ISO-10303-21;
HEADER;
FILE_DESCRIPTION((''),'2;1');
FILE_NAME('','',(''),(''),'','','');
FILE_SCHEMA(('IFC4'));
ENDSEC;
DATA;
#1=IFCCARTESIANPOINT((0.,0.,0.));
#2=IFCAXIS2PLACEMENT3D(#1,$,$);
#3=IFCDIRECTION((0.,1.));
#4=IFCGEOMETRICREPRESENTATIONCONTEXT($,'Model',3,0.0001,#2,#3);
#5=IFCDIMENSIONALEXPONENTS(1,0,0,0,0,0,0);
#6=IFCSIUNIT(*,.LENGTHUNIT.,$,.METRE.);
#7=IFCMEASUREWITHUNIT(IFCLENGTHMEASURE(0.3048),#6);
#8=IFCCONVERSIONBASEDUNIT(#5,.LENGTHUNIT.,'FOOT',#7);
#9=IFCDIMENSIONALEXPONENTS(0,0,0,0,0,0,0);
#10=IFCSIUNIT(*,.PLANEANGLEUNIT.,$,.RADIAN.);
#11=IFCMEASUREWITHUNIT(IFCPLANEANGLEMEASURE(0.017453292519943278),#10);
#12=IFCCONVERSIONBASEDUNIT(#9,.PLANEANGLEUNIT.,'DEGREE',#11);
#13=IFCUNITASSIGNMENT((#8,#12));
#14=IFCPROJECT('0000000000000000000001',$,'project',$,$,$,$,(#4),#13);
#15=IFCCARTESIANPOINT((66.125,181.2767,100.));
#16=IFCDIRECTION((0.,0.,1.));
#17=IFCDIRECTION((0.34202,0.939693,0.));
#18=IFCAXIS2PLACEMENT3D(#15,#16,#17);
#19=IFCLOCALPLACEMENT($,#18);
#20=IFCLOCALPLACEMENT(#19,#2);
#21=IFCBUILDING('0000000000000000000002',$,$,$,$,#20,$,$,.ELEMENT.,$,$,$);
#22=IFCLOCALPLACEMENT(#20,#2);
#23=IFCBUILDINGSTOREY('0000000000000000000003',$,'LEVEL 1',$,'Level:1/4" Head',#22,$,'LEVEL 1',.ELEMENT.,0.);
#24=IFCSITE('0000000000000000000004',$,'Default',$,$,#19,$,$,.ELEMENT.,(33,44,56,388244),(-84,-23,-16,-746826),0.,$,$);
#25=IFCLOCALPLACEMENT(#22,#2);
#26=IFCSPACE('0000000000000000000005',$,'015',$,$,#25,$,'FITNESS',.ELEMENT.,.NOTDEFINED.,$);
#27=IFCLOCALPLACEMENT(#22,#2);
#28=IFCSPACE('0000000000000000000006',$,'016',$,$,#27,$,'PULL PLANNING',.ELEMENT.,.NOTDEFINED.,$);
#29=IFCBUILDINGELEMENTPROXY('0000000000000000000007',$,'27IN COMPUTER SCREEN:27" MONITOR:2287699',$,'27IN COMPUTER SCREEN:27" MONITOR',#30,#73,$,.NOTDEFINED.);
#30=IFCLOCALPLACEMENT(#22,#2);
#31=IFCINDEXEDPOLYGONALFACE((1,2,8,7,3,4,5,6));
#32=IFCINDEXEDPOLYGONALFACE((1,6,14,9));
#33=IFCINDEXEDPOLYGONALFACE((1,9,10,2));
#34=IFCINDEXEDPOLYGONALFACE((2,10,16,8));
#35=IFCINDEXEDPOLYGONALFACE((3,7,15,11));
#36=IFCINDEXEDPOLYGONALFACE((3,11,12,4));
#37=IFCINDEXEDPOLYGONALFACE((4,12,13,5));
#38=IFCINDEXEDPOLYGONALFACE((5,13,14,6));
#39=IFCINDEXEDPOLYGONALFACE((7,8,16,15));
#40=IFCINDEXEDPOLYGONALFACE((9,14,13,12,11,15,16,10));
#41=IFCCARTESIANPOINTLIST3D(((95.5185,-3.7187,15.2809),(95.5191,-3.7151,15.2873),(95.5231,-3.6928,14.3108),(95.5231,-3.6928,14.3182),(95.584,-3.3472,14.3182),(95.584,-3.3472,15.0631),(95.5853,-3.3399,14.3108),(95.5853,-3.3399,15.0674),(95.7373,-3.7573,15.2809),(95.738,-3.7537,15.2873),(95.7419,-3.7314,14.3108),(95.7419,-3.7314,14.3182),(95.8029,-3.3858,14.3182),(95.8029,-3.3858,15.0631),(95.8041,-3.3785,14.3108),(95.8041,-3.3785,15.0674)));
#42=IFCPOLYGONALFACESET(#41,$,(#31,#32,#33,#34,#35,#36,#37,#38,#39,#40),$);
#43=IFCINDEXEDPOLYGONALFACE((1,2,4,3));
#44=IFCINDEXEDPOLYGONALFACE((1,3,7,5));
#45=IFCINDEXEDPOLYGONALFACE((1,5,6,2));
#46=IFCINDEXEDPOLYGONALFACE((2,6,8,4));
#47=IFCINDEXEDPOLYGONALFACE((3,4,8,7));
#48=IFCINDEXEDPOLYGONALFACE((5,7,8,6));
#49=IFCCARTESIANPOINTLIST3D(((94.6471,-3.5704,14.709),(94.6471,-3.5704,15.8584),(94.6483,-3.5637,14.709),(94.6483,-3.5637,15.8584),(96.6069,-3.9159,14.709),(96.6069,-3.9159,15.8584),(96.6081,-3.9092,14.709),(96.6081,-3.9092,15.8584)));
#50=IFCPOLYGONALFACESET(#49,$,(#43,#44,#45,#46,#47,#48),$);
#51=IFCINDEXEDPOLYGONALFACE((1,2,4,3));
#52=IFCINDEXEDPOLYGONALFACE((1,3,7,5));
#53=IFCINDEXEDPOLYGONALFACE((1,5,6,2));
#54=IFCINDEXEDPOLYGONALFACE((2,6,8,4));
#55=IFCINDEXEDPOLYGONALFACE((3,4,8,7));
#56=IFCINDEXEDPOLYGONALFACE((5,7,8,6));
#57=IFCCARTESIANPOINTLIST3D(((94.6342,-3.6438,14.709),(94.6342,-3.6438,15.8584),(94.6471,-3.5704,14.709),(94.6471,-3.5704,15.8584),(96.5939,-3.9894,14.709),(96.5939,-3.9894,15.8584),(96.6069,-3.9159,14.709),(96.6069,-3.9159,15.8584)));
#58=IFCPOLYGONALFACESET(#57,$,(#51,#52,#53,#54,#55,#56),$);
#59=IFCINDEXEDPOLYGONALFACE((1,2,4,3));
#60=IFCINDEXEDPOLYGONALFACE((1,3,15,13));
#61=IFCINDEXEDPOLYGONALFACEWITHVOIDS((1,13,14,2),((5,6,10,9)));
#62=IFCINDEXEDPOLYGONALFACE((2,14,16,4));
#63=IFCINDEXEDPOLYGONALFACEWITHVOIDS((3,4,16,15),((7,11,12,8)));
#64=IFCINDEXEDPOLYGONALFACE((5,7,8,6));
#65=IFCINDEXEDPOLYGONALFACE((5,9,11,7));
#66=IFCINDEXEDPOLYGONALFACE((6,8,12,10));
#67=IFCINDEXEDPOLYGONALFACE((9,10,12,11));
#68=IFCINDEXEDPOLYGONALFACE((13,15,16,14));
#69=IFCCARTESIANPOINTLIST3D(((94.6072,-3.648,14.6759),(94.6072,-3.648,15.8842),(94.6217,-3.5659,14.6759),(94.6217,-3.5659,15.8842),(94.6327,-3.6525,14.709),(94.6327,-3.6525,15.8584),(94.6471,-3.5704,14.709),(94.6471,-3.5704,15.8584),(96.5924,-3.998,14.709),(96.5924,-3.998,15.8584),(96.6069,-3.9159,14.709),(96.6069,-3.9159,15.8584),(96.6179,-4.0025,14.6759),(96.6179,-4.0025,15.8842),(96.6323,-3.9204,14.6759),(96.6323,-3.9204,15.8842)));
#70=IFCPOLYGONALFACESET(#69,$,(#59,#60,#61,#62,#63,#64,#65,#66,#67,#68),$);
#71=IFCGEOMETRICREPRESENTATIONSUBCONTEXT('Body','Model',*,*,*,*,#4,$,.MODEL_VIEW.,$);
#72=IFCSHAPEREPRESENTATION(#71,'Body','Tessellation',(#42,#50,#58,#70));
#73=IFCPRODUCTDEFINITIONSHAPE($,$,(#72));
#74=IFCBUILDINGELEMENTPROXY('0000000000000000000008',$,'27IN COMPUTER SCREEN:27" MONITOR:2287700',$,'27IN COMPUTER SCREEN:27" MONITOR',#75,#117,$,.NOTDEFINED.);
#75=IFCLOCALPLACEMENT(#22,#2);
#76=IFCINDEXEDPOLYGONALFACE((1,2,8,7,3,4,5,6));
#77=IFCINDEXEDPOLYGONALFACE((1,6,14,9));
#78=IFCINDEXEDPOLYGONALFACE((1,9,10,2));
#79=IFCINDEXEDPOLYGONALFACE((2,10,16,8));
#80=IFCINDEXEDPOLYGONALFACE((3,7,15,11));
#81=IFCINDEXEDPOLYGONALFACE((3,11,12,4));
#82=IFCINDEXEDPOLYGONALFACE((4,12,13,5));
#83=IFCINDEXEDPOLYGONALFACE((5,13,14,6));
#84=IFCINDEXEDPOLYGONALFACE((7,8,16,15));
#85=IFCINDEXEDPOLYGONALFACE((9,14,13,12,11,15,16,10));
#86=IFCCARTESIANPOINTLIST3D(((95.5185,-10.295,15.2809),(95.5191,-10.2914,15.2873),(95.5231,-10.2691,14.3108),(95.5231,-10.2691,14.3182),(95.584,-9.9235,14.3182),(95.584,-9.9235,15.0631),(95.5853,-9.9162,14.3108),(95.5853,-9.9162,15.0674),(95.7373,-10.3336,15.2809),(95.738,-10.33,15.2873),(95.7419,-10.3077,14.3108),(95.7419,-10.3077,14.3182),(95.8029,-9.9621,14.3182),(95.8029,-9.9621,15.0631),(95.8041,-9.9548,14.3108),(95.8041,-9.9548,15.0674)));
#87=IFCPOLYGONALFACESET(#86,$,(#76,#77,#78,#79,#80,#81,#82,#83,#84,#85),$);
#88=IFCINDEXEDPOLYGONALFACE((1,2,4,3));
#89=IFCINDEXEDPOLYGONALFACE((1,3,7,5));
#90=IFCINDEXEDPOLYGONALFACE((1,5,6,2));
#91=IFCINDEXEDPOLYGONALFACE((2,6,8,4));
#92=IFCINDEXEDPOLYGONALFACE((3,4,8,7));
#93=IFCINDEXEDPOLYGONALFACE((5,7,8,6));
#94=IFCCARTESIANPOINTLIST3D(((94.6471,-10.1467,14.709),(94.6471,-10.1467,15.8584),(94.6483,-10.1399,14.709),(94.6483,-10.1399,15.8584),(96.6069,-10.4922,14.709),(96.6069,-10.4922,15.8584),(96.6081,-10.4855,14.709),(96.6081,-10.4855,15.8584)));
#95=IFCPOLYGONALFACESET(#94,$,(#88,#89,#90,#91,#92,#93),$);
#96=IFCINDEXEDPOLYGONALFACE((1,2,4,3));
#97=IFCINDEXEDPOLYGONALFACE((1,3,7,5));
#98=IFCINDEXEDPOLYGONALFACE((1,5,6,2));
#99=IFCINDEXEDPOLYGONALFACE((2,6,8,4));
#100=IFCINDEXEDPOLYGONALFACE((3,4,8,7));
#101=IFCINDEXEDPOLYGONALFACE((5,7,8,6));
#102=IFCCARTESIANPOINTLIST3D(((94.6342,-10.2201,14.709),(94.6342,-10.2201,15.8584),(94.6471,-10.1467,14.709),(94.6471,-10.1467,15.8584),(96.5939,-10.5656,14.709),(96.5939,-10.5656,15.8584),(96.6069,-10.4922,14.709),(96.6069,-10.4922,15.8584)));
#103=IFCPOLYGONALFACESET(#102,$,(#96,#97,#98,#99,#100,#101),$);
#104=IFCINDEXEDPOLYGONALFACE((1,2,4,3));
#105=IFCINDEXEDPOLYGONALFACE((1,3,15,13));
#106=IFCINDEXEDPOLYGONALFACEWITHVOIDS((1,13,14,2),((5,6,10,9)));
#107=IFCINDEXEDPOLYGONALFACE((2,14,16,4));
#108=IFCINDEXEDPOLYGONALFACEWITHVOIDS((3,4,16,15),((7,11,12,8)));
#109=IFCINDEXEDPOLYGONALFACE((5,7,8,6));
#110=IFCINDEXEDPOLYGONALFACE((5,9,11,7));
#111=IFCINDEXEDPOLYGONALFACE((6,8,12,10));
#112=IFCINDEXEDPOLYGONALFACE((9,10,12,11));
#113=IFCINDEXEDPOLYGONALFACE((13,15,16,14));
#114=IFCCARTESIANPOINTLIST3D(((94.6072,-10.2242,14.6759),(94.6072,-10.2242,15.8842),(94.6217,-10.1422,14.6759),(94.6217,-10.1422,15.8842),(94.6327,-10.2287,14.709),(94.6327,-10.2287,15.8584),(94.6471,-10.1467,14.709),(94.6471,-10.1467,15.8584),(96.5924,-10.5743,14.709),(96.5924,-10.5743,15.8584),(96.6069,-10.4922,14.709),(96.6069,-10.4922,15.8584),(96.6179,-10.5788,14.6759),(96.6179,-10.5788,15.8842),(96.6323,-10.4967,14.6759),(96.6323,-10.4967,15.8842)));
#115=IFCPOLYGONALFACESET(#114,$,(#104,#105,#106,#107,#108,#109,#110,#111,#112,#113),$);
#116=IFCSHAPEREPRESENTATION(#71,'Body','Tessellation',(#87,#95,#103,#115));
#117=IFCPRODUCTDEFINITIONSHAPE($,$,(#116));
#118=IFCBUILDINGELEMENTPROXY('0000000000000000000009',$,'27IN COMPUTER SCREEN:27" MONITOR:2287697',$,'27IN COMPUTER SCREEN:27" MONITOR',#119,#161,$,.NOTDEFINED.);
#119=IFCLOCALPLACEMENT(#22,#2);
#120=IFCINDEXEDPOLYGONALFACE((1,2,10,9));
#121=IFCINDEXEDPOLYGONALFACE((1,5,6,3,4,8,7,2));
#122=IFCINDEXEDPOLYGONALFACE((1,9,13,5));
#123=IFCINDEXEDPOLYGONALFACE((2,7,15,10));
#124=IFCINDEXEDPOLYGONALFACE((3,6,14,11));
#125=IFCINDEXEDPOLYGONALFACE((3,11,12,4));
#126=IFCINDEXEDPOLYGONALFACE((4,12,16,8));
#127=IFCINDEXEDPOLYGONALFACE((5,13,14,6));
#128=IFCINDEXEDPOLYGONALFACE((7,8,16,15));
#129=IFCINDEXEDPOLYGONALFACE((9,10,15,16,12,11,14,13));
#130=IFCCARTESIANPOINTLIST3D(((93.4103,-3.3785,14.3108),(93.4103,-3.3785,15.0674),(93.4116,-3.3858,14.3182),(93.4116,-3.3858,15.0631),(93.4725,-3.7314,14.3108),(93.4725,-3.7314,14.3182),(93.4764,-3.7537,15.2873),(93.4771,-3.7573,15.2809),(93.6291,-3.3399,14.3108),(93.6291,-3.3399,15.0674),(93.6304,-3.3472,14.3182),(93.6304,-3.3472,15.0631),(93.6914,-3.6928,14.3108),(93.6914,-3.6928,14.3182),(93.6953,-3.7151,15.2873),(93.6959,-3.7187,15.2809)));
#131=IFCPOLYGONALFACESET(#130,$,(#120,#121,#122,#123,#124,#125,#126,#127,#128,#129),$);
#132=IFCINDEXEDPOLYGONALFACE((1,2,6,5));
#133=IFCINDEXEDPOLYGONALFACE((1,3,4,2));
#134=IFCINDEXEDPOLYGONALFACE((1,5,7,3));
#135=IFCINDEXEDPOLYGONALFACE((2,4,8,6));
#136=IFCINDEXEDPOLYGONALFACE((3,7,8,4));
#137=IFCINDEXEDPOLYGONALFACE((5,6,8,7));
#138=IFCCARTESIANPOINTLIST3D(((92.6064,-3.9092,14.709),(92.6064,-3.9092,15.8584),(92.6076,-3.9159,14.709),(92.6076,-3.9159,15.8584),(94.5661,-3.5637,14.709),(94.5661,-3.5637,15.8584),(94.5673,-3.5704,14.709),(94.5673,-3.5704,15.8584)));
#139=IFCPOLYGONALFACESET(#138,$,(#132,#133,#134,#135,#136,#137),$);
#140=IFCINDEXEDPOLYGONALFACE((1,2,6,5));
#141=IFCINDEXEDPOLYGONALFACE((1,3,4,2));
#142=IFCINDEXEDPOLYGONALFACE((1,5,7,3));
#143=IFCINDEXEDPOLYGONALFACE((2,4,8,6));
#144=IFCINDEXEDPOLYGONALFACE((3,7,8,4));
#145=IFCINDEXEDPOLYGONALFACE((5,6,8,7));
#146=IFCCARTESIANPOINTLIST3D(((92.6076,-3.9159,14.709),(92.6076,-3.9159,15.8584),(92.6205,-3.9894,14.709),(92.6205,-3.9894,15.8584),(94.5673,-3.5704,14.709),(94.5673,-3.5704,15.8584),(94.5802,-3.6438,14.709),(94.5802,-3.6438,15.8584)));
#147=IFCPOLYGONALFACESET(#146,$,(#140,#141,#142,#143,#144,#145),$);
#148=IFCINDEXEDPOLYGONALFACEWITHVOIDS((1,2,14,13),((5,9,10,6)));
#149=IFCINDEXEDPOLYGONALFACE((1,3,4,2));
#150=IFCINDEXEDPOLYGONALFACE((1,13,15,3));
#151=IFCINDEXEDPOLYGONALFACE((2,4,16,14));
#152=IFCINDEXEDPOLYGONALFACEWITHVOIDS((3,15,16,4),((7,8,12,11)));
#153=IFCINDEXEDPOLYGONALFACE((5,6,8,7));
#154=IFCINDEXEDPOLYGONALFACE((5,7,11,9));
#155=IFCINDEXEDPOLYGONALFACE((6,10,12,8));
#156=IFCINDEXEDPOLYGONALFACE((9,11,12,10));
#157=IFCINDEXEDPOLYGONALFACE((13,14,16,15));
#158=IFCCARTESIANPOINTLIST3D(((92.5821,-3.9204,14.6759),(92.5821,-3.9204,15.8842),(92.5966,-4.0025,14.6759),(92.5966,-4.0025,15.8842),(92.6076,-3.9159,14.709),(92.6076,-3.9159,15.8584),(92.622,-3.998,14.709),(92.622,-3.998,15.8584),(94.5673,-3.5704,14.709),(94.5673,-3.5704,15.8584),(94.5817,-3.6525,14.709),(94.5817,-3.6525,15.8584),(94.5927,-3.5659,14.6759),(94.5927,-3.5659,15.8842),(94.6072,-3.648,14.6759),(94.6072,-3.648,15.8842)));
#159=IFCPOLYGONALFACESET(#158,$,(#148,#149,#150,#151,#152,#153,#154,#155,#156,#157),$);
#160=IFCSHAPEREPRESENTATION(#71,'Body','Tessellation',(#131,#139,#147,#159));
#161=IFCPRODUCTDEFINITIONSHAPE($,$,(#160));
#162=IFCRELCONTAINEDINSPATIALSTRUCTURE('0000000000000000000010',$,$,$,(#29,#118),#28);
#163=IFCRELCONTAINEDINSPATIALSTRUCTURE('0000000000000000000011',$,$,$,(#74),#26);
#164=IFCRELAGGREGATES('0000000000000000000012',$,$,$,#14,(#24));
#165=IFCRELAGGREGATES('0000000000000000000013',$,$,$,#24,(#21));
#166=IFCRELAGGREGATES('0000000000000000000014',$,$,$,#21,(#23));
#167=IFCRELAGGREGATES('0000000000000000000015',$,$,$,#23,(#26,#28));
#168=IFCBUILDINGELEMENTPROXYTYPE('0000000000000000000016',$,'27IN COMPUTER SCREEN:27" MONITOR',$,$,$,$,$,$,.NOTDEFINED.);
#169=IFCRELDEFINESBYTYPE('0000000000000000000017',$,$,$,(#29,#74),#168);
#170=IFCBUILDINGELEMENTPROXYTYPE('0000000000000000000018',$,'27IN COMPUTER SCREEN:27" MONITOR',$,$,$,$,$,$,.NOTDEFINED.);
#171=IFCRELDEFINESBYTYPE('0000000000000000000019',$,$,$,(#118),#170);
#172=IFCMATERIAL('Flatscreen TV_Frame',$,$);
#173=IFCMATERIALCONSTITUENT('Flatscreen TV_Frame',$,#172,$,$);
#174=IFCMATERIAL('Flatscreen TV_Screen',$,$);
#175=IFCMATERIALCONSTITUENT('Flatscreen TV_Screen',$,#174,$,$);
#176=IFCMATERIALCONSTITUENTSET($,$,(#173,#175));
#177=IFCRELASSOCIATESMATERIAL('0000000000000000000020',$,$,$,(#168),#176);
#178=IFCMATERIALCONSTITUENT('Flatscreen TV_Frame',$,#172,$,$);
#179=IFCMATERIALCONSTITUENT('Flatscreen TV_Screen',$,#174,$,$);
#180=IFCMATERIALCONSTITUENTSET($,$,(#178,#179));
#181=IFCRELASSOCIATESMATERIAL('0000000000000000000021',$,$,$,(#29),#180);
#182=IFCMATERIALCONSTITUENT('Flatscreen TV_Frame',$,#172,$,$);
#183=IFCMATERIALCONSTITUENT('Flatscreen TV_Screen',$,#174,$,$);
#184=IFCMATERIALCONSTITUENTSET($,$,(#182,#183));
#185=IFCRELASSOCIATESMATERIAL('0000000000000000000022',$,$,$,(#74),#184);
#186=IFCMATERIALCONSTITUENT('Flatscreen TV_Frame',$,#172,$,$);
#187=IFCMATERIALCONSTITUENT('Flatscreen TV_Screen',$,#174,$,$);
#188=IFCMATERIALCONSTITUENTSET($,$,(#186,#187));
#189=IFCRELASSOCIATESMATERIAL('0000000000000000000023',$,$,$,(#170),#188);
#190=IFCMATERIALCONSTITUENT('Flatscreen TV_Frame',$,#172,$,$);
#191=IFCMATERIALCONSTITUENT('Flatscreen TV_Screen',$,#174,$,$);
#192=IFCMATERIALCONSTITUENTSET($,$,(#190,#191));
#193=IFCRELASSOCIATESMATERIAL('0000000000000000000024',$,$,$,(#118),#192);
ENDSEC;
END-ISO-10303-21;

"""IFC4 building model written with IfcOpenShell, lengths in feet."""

from ifc_helpers import new_model, entity, si_unit, converted_unit, direction, frame, frame_2d, origin, origin_2d_with_axis, place, context, subcontext, project, spatial, polyline, rectangle, outline, extrude, source, transform, mapped, material, constituent, constituent_set, type_object, type_shapes, element, save


model = new_model("IFC4")

# Units and contexts
model_context = context("Model", 3, precision=0.0001, world=origin(), true_north=direction((0.0, 1.0)))
body_context = subcontext(model_context, "Body", "Model", "MODEL_VIEW")
ifc_project = project(units=[converted_unit("LENGTHUNIT", "FOOT", entity("IfcLengthMeasure", 0.3048), si_unit("LENGTHUNIT", "METRE"), dimensions=[1, 0, 0, 0, 0, 0, 0]), converted_unit("PLANEANGLEUNIT", "DEGREE", entity("IfcPlaneAngleMeasure", 0.017453292519943278), si_unit("PLANEANGLEUNIT", "RADIAN"), dimensions=[0, 0, 0, 0, 0, 0, 0])], contexts=[model_context])

# Site, building, storey
site_placement = place(None, frame((66.125, 181.2767, 100.0), z_axis=(0.0, 0.0, 1.0), x_axis=(0.34202, 0.939693, 0.0)))
site = spatial("IfcSite", under=ifc_project, at=site_placement, Name="Default", CompositionType="ELEMENT", RefLatitude=(33, 44, 56, 388244), RefLongitude=(-84, -23, -16, -746826), RefElevation=0.0)
building_placement = place(site_placement, origin())
building = spatial("IfcBuilding", under=site, at=building_placement, CompositionType="ELEMENT")
storey_placement = place(building_placement, origin())
storey = spatial("IfcBuildingStorey", under=building, at=storey_placement, Name="LEVEL 1", ObjectType="Level:1/4\" Head", LongName="LEVEL 1", CompositionType="ELEMENT", Elevation=0.0)

# Shared definitions
space_1_placement = place(storey_placement, origin())
space_1 = spatial("IfcSpace", under=storey, at=space_1_placement, Name="015", LongName="FITNESS", CompositionType="ELEMENT", PredefinedType="NOTDEFINED")

# Shared definitions
ifc_material_1 = material(Name="Flatscreen TV_Frame")
ifc_material_2 = material(Name="Flatscreen TV_Screen")
ifc_constituent_1 = constituent(ifc_material_1, Name="Flatscreen TV_Frame")
ifc_constituent_2 = constituent(ifc_material_2, Name="Flatscreen TV_Screen")
ifc_constituent_set_1 = constituent_set(constituents=[ifc_constituent_1, ifc_constituent_2])
building_element_proxy_type_1 = type_object("IfcBuildingElementProxyType", Name="27IN COMPUTER SCREEN:27\" MONITOR", PredefinedType="NOTDEFINED", material=ifc_constituent_set_1)
shared_shape_1 = source(origin(), body_context, "Body", "SweptSolid", [
    extrude(outline(polyline([(-0.4392, -0.3657), (-0.4392, -0.3731), (0.0007, -0.3731), (0.379, 0.2821), (0.0686, 0.4613), (0.0649, 0.4548), (0.3688, 0.2794), (-0.0036, -0.3657), (-0.4392, -0.3657)])), frame((-0.1111, -0.0264, 0.0687), z_axis=(-1.0, 0.0, 0.0), x_axis=(0.0, 0.866025, -0.5)), (0.0, 0.0, -1.0), 0.2222),
    extrude(rectangle(XDim=0.0068, YDim=1.9899, at=origin_2d_with_axis()), frame((0.0, -0.2257, 0.0331), z_axis=(0.0, 0.0, 1.0), x_axis=(0.0, 1.0, 0.0)), (0.0, 0.0, 1.0), 1.1493),
    extrude(rectangle(XDim=0.0746, YDim=1.9899, at=frame_2d((0.0, 0.0), x_axis=(1.0, 0.0))), frame((0.0, -0.2664, 0.0331), z_axis=(0.0, 0.0, 1.0), x_axis=(0.0, 1.0, 0.0)), (0.0, 0.0, 1.0), 1.1493),
    extrude(outline(polyline([(-0.6042, -1.0208), (0.6042, -1.0208), (0.6042, 1.0208), (-0.6042, 1.0208), (-0.6042, -1.0208)]), holes=[polyline([(-0.5783, -0.995), (-0.5783, 0.995), (0.571, 0.995), (0.571, -0.995), (-0.5783, -0.995)])]), frame((0.0, -0.3125, 0.6042), z_axis=(0.0, 1.0, 0.0), x_axis=(0.0, 0.0, -1.0)), (0.0, 0.0, 1.0), 0.0833),
])
type_shapes(building_element_proxy_type_1, [shared_shape_1])

# Shared definitions
space_2_placement = place(storey_placement, origin())
space_2 = spatial("IfcSpace", under=storey, at=space_2_placement, Name="016", LongName="PULL PLANNING", CompositionType="ELEMENT", PredefinedType="NOTDEFINED")

# Building element proxies
ifc_constituent_3 = constituent(ifc_material_1, Name="Flatscreen TV_Frame")
ifc_constituent_4 = constituent(ifc_material_2, Name="Flatscreen TV_Screen")
ifc_constituent_set_2 = constituent_set(constituents=[ifc_constituent_3, ifc_constituent_4])
proxy_1_placement = place(space_2_placement, frame((95.6668, -3.5175, 14.6759), z_axis=(0.0, 0.0, 1.0), x_axis=(0.984808, -0.173648, 0.0)))
element("IfcBuildingElementProxy", 1, at=proxy_1_placement, inside=space_2, type_object=building_element_proxy_type_1, material=ifc_constituent_set_2, Name="27IN COMPUTER SCREEN:27\" MONITOR:2287699", ObjectType="27IN COMPUTER SCREEN:27\" MONITOR", PredefinedType="NOTDEFINED", context=body_context, shape_type="MappedRepresentation", body=[
    mapped(shared_shape_1, transform((0.0, 0.0, 0.0), scale=1.0)),
])
ifc_constituent_5 = constituent(ifc_material_1, Name="Flatscreen TV_Frame")
ifc_constituent_6 = constituent(ifc_material_2, Name="Flatscreen TV_Screen")
ifc_constituent_set_3 = constituent_set(constituents=[ifc_constituent_5, ifc_constituent_6])
proxy_2_placement = place(space_1_placement, frame((95.6668, -10.0938, 14.6759), z_axis=(0.0, 0.0, 1.0), x_axis=(0.984808, -0.173648, 0.0)))
element("IfcBuildingElementProxy", 2, at=proxy_2_placement, inside=space_1, type_object=building_element_proxy_type_1, material=ifc_constituent_set_3, Name="27IN COMPUTER SCREEN:27\" MONITOR:2287700", ObjectType="27IN COMPUTER SCREEN:27\" MONITOR", PredefinedType="NOTDEFINED", context=body_context, shape_type="MappedRepresentation", body=[
    mapped(shared_shape_1, transform((0.0, 0.0, 0.0), scale=1.0)),
])
ifc_constituent_7 = constituent(ifc_material_1, Name="Flatscreen TV_Frame")
ifc_constituent_8 = constituent(ifc_material_2, Name="Flatscreen TV_Screen")
ifc_constituent_set_4 = constituent_set(constituents=[ifc_constituent_7, ifc_constituent_8])
ifc_constituent_9 = constituent(ifc_material_1, Name="Flatscreen TV_Frame")
ifc_constituent_10 = constituent(ifc_material_2, Name="Flatscreen TV_Screen")
ifc_constituent_set_5 = constituent_set(constituents=[ifc_constituent_9, ifc_constituent_10])
building_element_proxy_type_2 = type_object("IfcBuildingElementProxyType", Name="27IN COMPUTER SCREEN:27\" MONITOR", PredefinedType="NOTDEFINED", material=ifc_constituent_set_5)
shared_shape_2 = source(origin(), body_context, "Body", "SweptSolid", [
    extrude(outline(polyline([(0.3657, -0.4392), (0.3731, -0.4392), (0.3731, 0.0007), (-0.2821, 0.379), (-0.4613, 0.0686), (-0.4548, 0.0649), (-0.2794, 0.3688), (0.3657, -0.0036), (0.3657, -0.4392)])), frame((-0.1111, 0.0264, 0.0687), z_axis=(1.0, 0.0, 0.0), x_axis=(0.0, -0.5, 0.866025)), (0.0, 0.0, 1.0), 0.2222),
    extrude(rectangle(XDim=1.9899, YDim=0.0068, at=origin_2d_with_axis()), frame((0.0, 0.2257, 0.0331), z_axis=(0.0, 0.0, 1.0), x_axis=(-1.0, 0.0, 0.0)), (0.0, 0.0, 1.0), 1.1493),
    extrude(rectangle(XDim=1.9899, YDim=0.0746, at=frame_2d((0.0, 0.0), x_axis=(1.0, 0.0))), frame((0.0, 0.2664, 0.0331), z_axis=(0.0, 0.0, 1.0), x_axis=(-1.0, 0.0, 0.0)), (0.0, 0.0, 1.0), 1.1493),
    extrude(outline(polyline([(-0.6042, -1.0208), (0.6042, -1.0208), (0.6042, 1.0208), (-0.6042, 1.0208), (-0.6042, -1.0208)]), holes=[polyline([(-0.5783, -0.995), (-0.5783, 0.995), (0.571, 0.995), (0.571, -0.995), (-0.5783, -0.995)])]), frame((0.0, 0.2292, 0.6042), z_axis=(0.0, 1.0, 0.0), x_axis=(0.0, 0.0, -1.0)), (0.0, 0.0, 1.0), 0.0833),
])
type_shapes(building_element_proxy_type_2, [shared_shape_2])
proxy_3_placement = place(space_2_placement, frame((93.5476, -3.5175, 14.6759), z_axis=(0.0, 0.0, 1.0), x_axis=(-0.984808, -0.173648, 0.0)))
element("IfcBuildingElementProxy", 3, at=proxy_3_placement, inside=space_2, type_object=building_element_proxy_type_2, material=ifc_constituent_set_4, Name="27IN COMPUTER SCREEN:27\" MONITOR:2287697", ObjectType="27IN COMPUTER SCREEN:27\" MONITOR", PredefinedType="NOTDEFINED", context=body_context, shape_type="MappedRepresentation", body=[
    mapped(shared_shape_2, transform((0.0, 0.0, 0.0), scale=1.0)),
])

save(model, "model.ifc")
